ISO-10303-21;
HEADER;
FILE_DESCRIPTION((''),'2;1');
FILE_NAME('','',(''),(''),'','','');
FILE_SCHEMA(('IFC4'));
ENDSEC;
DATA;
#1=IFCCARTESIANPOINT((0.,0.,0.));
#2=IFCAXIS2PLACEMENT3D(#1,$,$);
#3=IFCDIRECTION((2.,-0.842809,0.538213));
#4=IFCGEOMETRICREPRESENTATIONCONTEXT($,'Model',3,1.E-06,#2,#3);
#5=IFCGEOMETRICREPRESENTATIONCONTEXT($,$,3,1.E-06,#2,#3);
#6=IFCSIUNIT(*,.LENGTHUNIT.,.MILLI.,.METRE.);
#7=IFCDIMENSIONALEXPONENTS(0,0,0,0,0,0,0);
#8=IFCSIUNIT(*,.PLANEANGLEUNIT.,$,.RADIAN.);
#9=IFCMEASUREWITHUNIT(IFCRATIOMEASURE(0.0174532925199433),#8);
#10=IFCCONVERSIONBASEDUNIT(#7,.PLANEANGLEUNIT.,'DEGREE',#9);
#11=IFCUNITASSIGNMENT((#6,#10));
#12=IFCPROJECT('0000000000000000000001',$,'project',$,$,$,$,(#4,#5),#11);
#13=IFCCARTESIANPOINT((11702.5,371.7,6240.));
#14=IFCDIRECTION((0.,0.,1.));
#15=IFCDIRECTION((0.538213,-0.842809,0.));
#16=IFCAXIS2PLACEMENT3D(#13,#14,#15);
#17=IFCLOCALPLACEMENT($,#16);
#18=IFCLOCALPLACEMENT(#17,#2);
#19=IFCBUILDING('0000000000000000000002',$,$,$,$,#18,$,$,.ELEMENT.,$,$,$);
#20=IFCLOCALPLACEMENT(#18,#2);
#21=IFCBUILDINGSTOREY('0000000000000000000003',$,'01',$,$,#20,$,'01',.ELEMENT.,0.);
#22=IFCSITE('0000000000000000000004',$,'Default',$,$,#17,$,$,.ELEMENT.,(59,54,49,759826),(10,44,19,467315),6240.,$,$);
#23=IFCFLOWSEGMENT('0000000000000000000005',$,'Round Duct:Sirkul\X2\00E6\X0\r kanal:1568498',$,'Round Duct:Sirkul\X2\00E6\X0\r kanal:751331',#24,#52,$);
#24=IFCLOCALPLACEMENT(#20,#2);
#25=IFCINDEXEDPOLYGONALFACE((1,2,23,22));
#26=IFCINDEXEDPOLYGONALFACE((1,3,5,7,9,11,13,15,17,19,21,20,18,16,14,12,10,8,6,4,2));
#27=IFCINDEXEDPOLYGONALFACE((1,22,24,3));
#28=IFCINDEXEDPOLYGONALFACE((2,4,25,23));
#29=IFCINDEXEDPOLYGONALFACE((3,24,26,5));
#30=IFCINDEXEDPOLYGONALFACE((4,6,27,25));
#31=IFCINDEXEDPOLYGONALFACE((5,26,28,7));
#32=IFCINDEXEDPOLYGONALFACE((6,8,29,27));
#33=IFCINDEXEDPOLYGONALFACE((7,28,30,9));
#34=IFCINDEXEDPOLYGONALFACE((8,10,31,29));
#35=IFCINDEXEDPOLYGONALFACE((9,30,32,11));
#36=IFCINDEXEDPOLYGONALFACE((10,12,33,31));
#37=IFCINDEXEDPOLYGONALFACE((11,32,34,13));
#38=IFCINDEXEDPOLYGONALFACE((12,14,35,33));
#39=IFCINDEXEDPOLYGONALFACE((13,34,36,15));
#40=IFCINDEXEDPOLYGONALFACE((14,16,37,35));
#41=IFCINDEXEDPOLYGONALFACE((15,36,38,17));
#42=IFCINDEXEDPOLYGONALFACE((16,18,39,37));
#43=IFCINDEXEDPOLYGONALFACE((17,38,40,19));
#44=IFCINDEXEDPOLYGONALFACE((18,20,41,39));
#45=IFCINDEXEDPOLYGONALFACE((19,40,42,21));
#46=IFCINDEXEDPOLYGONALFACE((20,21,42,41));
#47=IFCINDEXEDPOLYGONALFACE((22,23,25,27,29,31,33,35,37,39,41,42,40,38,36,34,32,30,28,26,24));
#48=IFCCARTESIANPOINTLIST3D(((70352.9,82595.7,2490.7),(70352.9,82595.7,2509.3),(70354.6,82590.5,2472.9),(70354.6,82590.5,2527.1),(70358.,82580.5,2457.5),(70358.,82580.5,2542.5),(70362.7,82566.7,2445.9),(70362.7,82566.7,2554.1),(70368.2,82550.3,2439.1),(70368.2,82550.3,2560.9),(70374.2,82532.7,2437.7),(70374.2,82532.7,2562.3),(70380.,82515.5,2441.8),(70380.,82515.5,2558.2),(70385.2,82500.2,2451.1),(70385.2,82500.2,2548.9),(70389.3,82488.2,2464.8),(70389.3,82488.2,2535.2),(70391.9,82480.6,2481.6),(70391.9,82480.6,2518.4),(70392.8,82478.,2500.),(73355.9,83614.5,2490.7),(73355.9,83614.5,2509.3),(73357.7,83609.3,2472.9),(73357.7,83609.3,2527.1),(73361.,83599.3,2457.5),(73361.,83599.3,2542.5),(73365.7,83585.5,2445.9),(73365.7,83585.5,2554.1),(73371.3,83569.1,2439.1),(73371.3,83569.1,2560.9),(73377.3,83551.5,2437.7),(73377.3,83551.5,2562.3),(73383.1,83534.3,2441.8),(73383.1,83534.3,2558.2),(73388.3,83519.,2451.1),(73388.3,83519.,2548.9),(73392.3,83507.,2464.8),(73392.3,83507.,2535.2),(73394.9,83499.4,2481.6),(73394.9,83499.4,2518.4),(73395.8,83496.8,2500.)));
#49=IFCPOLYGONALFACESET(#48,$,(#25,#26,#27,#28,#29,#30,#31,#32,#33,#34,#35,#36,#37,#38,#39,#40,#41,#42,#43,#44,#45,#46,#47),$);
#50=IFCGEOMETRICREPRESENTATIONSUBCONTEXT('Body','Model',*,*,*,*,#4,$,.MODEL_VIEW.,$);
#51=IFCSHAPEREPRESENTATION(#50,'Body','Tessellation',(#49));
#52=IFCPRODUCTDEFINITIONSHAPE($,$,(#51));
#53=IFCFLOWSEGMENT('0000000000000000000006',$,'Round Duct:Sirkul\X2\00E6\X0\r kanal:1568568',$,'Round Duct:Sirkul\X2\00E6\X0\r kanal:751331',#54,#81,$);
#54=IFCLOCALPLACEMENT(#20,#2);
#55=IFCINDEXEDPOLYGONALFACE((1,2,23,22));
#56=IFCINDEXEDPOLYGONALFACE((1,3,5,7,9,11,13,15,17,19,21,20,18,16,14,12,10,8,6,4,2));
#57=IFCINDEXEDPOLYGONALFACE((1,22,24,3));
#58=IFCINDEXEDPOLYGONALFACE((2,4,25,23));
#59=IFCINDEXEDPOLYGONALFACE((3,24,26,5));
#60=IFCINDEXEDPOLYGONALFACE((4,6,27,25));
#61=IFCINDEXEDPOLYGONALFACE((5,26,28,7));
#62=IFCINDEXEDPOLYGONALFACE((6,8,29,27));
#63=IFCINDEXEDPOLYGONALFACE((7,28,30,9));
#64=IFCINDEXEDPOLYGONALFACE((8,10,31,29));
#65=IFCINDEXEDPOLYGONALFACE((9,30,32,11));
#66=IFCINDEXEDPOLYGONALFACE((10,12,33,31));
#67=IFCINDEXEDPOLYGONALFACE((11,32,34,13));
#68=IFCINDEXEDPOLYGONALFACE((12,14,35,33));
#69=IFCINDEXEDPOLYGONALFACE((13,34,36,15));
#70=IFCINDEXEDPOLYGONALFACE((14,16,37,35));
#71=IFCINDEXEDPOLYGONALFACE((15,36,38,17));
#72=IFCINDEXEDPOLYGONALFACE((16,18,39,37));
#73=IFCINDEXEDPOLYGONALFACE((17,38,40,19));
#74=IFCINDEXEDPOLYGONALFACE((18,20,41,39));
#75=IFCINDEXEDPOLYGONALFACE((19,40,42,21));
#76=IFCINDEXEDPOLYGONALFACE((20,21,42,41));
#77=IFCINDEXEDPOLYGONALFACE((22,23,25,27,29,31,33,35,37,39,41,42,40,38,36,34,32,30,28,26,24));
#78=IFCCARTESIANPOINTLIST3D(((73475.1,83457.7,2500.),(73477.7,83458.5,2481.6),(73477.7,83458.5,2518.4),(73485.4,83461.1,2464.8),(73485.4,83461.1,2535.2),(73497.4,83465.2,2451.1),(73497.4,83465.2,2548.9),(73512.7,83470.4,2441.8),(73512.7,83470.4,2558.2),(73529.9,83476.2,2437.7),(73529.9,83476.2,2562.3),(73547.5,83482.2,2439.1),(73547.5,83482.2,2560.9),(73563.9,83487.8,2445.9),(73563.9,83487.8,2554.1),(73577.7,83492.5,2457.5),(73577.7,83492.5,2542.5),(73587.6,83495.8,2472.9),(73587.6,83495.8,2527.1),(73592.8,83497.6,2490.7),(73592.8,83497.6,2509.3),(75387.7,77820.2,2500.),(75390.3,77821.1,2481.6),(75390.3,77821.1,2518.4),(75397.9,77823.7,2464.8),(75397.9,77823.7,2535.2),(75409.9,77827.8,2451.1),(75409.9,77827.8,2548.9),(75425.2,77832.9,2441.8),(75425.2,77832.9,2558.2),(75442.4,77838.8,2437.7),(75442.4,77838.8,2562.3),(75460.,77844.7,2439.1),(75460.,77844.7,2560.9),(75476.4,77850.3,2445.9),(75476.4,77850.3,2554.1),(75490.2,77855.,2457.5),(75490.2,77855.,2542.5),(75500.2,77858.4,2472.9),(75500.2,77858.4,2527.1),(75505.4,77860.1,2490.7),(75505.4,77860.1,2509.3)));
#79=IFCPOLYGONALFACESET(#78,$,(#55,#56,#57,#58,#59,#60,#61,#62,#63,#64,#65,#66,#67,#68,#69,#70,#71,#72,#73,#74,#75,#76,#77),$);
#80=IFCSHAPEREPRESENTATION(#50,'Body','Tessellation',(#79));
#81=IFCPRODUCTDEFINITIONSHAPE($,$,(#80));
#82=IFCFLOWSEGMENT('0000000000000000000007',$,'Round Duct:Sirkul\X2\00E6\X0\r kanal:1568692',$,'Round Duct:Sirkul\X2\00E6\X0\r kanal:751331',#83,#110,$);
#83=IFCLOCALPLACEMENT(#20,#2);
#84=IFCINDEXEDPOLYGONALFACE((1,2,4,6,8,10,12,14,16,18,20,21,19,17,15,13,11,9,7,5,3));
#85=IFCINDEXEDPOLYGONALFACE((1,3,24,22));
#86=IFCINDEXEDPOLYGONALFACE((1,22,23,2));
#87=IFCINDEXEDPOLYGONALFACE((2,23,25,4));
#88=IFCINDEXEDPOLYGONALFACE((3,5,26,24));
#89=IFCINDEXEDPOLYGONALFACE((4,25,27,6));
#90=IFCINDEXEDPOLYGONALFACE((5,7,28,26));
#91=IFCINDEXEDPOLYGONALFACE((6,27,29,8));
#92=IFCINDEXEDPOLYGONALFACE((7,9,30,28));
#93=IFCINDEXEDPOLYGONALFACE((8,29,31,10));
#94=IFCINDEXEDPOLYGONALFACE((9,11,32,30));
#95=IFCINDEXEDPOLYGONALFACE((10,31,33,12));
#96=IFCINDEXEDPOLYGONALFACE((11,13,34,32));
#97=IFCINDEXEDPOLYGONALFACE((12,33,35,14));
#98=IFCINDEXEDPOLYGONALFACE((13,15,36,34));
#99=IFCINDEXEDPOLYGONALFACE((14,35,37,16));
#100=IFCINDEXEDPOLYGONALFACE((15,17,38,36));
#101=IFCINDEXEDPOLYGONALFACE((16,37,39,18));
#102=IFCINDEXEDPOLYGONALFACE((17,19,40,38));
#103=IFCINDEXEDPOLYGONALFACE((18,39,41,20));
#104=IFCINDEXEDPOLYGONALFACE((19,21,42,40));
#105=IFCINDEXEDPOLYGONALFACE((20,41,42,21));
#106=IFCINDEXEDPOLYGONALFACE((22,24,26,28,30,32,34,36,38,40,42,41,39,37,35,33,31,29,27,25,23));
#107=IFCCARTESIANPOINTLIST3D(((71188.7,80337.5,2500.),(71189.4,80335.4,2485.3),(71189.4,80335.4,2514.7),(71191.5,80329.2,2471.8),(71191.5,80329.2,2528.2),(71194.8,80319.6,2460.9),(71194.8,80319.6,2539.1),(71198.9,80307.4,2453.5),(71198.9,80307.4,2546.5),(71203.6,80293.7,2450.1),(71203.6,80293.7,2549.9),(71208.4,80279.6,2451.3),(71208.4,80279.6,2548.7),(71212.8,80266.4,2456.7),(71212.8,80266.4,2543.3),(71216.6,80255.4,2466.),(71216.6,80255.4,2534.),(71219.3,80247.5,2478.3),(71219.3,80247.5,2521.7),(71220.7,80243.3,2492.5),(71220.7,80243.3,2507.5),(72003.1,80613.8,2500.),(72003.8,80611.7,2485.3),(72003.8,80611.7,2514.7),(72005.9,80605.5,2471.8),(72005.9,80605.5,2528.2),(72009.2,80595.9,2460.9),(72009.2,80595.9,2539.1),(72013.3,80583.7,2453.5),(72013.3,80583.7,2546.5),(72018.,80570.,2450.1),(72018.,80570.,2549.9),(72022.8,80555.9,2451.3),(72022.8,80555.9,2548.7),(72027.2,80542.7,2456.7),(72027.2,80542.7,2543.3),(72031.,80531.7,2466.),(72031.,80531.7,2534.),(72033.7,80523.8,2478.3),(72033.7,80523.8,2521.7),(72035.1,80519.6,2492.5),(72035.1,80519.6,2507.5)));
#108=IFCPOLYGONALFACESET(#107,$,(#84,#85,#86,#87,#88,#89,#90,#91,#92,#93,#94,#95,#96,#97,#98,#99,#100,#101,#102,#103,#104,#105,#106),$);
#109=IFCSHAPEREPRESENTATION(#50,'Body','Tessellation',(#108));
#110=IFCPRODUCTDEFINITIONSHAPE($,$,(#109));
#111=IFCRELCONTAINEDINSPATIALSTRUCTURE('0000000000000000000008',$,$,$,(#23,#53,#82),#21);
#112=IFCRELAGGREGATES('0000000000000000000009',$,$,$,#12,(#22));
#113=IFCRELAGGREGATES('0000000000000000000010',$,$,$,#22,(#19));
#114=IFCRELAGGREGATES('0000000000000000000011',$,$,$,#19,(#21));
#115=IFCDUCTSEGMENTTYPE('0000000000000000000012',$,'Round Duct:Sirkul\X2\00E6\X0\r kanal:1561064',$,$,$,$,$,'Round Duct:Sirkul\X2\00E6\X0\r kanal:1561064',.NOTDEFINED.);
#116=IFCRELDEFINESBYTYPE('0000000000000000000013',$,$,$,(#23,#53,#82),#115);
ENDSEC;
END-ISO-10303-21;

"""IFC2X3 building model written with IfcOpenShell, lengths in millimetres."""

from ifc_helpers import new_model, entity, si_unit, converted_unit, direction, frame, frame_2d, origin, origin_2d_with_axis, place, context, subcontext, project, spatial, circle, extrude, type_object, element, save


model = new_model("IFC2X3")

# Units and contexts
model_context = context("Model", 3, precision=1e-06, world=origin(), true_north=direction((2.0, -0.842809, 0.538213)))
context_of_model = context(None, 3, precision=1e-06, world=origin(), true_north=direction((2.0, -0.842809, 0.538213)))
body_context = subcontext(model_context, "Body", "Model", "MODEL_VIEW")
ifc_project = project(units=[si_unit("LENGTHUNIT", "METRE", prefix="MILLI"), converted_unit("PLANEANGLEUNIT", "DEGREE", entity("IfcRatioMeasure", 0.0174532925199433), si_unit("PLANEANGLEUNIT", "RADIAN"), dimensions=[0, 0, 0, 0, 0, 0, 0])], contexts=[model_context, context_of_model])

# Site, building, storey
site_placement = place(None, frame((11702.5, 371.7, 6240.0), z_axis=(0.0, 0.0, 1.0), x_axis=(0.538213, -0.842809, 0.0)))
site = spatial("IfcSite", under=ifc_project, at=site_placement, Name="Default", CompositionType="ELEMENT", RefLatitude=(59, 54, 49, 759826), RefLongitude=(10, 44, 19, 467315), RefElevation=6240.0)
building_placement = place(site_placement, origin())
building = spatial("IfcBuilding", under=site, at=building_placement, CompositionType="ELEMENT")
storey_placement = place(building_placement, origin())
storey = spatial("IfcBuildingStorey", under=building, at=storey_placement, Name="01", LongName="01", CompositionType="ELEMENT", Elevation=0.0)

# Flow segments
duct_segment_type = type_object("IfcDuctSegmentType", Name="Round Duct:Sirkulær kanal:1561064", ElementType="Round Duct:Sirkulær kanal:1561064", PredefinedType="NOTDEFINED")
flow_segment_1_placement = place(storey_placement, origin())
element("IfcFlowSegment", 1, at=flow_segment_1_placement, inside=storey, type_object=duct_segment_type, Name="Round Duct:Sirkulær kanal:1568498", ObjectType="Round Duct:Sirkulær kanal:751331", context=body_context, shape_type="SweptSolid", body=[
    extrude(circle(Radius=62.5, at=origin_2d_with_axis()), frame((70372.7, 82537.1, 2500.0), z_axis=(0.946986, 0.321274, 0.0), x_axis=(0.321274, -0.946986, 0.0)), (0.0, 0.0, 1.0), 3171.2),
])
flow_segment_2_placement = place(storey_placement, origin())
element("IfcFlowSegment", 2, at=flow_segment_2_placement, inside=storey, type_object=duct_segment_type, Name="Round Duct:Sirkulær kanal:1568568", ObjectType="Round Duct:Sirkulær kanal:751331", context=body_context, shape_type="SweptSolid", body=[
    extrude(circle(Radius=62.5, at=frame_2d((0.0, 0.0), x_axis=(1.0, 0.0))), frame((73534.3, 83477.7, 2500.0), z_axis=(0.321274, -0.946986, 0.0), x_axis=(-0.946986, -0.321274, 0.0)), (0.0, 0.0, 1.0), 5953.1),
])
flow_segment_3_placement = place(storey_placement, origin())
element("IfcFlowSegment", 3, at=flow_segment_3_placement, inside=storey, type_object=duct_segment_type, Name="Round Duct:Sirkulær kanal:1568692", ObjectType="Round Duct:Sirkulær kanal:751331", context=body_context, shape_type="SweptSolid", body=[
    extrude(circle(Radius=50.0, at=origin_2d_with_axis()), frame((71204.8, 80290.1, 2500.0), z_axis=(0.946986, 0.321274, 0.0), x_axis=(-0.321274, 0.946986, 0.0)), (0.0, 0.0, 1.0), 860.0),
])

save(model, "model.ifc")
